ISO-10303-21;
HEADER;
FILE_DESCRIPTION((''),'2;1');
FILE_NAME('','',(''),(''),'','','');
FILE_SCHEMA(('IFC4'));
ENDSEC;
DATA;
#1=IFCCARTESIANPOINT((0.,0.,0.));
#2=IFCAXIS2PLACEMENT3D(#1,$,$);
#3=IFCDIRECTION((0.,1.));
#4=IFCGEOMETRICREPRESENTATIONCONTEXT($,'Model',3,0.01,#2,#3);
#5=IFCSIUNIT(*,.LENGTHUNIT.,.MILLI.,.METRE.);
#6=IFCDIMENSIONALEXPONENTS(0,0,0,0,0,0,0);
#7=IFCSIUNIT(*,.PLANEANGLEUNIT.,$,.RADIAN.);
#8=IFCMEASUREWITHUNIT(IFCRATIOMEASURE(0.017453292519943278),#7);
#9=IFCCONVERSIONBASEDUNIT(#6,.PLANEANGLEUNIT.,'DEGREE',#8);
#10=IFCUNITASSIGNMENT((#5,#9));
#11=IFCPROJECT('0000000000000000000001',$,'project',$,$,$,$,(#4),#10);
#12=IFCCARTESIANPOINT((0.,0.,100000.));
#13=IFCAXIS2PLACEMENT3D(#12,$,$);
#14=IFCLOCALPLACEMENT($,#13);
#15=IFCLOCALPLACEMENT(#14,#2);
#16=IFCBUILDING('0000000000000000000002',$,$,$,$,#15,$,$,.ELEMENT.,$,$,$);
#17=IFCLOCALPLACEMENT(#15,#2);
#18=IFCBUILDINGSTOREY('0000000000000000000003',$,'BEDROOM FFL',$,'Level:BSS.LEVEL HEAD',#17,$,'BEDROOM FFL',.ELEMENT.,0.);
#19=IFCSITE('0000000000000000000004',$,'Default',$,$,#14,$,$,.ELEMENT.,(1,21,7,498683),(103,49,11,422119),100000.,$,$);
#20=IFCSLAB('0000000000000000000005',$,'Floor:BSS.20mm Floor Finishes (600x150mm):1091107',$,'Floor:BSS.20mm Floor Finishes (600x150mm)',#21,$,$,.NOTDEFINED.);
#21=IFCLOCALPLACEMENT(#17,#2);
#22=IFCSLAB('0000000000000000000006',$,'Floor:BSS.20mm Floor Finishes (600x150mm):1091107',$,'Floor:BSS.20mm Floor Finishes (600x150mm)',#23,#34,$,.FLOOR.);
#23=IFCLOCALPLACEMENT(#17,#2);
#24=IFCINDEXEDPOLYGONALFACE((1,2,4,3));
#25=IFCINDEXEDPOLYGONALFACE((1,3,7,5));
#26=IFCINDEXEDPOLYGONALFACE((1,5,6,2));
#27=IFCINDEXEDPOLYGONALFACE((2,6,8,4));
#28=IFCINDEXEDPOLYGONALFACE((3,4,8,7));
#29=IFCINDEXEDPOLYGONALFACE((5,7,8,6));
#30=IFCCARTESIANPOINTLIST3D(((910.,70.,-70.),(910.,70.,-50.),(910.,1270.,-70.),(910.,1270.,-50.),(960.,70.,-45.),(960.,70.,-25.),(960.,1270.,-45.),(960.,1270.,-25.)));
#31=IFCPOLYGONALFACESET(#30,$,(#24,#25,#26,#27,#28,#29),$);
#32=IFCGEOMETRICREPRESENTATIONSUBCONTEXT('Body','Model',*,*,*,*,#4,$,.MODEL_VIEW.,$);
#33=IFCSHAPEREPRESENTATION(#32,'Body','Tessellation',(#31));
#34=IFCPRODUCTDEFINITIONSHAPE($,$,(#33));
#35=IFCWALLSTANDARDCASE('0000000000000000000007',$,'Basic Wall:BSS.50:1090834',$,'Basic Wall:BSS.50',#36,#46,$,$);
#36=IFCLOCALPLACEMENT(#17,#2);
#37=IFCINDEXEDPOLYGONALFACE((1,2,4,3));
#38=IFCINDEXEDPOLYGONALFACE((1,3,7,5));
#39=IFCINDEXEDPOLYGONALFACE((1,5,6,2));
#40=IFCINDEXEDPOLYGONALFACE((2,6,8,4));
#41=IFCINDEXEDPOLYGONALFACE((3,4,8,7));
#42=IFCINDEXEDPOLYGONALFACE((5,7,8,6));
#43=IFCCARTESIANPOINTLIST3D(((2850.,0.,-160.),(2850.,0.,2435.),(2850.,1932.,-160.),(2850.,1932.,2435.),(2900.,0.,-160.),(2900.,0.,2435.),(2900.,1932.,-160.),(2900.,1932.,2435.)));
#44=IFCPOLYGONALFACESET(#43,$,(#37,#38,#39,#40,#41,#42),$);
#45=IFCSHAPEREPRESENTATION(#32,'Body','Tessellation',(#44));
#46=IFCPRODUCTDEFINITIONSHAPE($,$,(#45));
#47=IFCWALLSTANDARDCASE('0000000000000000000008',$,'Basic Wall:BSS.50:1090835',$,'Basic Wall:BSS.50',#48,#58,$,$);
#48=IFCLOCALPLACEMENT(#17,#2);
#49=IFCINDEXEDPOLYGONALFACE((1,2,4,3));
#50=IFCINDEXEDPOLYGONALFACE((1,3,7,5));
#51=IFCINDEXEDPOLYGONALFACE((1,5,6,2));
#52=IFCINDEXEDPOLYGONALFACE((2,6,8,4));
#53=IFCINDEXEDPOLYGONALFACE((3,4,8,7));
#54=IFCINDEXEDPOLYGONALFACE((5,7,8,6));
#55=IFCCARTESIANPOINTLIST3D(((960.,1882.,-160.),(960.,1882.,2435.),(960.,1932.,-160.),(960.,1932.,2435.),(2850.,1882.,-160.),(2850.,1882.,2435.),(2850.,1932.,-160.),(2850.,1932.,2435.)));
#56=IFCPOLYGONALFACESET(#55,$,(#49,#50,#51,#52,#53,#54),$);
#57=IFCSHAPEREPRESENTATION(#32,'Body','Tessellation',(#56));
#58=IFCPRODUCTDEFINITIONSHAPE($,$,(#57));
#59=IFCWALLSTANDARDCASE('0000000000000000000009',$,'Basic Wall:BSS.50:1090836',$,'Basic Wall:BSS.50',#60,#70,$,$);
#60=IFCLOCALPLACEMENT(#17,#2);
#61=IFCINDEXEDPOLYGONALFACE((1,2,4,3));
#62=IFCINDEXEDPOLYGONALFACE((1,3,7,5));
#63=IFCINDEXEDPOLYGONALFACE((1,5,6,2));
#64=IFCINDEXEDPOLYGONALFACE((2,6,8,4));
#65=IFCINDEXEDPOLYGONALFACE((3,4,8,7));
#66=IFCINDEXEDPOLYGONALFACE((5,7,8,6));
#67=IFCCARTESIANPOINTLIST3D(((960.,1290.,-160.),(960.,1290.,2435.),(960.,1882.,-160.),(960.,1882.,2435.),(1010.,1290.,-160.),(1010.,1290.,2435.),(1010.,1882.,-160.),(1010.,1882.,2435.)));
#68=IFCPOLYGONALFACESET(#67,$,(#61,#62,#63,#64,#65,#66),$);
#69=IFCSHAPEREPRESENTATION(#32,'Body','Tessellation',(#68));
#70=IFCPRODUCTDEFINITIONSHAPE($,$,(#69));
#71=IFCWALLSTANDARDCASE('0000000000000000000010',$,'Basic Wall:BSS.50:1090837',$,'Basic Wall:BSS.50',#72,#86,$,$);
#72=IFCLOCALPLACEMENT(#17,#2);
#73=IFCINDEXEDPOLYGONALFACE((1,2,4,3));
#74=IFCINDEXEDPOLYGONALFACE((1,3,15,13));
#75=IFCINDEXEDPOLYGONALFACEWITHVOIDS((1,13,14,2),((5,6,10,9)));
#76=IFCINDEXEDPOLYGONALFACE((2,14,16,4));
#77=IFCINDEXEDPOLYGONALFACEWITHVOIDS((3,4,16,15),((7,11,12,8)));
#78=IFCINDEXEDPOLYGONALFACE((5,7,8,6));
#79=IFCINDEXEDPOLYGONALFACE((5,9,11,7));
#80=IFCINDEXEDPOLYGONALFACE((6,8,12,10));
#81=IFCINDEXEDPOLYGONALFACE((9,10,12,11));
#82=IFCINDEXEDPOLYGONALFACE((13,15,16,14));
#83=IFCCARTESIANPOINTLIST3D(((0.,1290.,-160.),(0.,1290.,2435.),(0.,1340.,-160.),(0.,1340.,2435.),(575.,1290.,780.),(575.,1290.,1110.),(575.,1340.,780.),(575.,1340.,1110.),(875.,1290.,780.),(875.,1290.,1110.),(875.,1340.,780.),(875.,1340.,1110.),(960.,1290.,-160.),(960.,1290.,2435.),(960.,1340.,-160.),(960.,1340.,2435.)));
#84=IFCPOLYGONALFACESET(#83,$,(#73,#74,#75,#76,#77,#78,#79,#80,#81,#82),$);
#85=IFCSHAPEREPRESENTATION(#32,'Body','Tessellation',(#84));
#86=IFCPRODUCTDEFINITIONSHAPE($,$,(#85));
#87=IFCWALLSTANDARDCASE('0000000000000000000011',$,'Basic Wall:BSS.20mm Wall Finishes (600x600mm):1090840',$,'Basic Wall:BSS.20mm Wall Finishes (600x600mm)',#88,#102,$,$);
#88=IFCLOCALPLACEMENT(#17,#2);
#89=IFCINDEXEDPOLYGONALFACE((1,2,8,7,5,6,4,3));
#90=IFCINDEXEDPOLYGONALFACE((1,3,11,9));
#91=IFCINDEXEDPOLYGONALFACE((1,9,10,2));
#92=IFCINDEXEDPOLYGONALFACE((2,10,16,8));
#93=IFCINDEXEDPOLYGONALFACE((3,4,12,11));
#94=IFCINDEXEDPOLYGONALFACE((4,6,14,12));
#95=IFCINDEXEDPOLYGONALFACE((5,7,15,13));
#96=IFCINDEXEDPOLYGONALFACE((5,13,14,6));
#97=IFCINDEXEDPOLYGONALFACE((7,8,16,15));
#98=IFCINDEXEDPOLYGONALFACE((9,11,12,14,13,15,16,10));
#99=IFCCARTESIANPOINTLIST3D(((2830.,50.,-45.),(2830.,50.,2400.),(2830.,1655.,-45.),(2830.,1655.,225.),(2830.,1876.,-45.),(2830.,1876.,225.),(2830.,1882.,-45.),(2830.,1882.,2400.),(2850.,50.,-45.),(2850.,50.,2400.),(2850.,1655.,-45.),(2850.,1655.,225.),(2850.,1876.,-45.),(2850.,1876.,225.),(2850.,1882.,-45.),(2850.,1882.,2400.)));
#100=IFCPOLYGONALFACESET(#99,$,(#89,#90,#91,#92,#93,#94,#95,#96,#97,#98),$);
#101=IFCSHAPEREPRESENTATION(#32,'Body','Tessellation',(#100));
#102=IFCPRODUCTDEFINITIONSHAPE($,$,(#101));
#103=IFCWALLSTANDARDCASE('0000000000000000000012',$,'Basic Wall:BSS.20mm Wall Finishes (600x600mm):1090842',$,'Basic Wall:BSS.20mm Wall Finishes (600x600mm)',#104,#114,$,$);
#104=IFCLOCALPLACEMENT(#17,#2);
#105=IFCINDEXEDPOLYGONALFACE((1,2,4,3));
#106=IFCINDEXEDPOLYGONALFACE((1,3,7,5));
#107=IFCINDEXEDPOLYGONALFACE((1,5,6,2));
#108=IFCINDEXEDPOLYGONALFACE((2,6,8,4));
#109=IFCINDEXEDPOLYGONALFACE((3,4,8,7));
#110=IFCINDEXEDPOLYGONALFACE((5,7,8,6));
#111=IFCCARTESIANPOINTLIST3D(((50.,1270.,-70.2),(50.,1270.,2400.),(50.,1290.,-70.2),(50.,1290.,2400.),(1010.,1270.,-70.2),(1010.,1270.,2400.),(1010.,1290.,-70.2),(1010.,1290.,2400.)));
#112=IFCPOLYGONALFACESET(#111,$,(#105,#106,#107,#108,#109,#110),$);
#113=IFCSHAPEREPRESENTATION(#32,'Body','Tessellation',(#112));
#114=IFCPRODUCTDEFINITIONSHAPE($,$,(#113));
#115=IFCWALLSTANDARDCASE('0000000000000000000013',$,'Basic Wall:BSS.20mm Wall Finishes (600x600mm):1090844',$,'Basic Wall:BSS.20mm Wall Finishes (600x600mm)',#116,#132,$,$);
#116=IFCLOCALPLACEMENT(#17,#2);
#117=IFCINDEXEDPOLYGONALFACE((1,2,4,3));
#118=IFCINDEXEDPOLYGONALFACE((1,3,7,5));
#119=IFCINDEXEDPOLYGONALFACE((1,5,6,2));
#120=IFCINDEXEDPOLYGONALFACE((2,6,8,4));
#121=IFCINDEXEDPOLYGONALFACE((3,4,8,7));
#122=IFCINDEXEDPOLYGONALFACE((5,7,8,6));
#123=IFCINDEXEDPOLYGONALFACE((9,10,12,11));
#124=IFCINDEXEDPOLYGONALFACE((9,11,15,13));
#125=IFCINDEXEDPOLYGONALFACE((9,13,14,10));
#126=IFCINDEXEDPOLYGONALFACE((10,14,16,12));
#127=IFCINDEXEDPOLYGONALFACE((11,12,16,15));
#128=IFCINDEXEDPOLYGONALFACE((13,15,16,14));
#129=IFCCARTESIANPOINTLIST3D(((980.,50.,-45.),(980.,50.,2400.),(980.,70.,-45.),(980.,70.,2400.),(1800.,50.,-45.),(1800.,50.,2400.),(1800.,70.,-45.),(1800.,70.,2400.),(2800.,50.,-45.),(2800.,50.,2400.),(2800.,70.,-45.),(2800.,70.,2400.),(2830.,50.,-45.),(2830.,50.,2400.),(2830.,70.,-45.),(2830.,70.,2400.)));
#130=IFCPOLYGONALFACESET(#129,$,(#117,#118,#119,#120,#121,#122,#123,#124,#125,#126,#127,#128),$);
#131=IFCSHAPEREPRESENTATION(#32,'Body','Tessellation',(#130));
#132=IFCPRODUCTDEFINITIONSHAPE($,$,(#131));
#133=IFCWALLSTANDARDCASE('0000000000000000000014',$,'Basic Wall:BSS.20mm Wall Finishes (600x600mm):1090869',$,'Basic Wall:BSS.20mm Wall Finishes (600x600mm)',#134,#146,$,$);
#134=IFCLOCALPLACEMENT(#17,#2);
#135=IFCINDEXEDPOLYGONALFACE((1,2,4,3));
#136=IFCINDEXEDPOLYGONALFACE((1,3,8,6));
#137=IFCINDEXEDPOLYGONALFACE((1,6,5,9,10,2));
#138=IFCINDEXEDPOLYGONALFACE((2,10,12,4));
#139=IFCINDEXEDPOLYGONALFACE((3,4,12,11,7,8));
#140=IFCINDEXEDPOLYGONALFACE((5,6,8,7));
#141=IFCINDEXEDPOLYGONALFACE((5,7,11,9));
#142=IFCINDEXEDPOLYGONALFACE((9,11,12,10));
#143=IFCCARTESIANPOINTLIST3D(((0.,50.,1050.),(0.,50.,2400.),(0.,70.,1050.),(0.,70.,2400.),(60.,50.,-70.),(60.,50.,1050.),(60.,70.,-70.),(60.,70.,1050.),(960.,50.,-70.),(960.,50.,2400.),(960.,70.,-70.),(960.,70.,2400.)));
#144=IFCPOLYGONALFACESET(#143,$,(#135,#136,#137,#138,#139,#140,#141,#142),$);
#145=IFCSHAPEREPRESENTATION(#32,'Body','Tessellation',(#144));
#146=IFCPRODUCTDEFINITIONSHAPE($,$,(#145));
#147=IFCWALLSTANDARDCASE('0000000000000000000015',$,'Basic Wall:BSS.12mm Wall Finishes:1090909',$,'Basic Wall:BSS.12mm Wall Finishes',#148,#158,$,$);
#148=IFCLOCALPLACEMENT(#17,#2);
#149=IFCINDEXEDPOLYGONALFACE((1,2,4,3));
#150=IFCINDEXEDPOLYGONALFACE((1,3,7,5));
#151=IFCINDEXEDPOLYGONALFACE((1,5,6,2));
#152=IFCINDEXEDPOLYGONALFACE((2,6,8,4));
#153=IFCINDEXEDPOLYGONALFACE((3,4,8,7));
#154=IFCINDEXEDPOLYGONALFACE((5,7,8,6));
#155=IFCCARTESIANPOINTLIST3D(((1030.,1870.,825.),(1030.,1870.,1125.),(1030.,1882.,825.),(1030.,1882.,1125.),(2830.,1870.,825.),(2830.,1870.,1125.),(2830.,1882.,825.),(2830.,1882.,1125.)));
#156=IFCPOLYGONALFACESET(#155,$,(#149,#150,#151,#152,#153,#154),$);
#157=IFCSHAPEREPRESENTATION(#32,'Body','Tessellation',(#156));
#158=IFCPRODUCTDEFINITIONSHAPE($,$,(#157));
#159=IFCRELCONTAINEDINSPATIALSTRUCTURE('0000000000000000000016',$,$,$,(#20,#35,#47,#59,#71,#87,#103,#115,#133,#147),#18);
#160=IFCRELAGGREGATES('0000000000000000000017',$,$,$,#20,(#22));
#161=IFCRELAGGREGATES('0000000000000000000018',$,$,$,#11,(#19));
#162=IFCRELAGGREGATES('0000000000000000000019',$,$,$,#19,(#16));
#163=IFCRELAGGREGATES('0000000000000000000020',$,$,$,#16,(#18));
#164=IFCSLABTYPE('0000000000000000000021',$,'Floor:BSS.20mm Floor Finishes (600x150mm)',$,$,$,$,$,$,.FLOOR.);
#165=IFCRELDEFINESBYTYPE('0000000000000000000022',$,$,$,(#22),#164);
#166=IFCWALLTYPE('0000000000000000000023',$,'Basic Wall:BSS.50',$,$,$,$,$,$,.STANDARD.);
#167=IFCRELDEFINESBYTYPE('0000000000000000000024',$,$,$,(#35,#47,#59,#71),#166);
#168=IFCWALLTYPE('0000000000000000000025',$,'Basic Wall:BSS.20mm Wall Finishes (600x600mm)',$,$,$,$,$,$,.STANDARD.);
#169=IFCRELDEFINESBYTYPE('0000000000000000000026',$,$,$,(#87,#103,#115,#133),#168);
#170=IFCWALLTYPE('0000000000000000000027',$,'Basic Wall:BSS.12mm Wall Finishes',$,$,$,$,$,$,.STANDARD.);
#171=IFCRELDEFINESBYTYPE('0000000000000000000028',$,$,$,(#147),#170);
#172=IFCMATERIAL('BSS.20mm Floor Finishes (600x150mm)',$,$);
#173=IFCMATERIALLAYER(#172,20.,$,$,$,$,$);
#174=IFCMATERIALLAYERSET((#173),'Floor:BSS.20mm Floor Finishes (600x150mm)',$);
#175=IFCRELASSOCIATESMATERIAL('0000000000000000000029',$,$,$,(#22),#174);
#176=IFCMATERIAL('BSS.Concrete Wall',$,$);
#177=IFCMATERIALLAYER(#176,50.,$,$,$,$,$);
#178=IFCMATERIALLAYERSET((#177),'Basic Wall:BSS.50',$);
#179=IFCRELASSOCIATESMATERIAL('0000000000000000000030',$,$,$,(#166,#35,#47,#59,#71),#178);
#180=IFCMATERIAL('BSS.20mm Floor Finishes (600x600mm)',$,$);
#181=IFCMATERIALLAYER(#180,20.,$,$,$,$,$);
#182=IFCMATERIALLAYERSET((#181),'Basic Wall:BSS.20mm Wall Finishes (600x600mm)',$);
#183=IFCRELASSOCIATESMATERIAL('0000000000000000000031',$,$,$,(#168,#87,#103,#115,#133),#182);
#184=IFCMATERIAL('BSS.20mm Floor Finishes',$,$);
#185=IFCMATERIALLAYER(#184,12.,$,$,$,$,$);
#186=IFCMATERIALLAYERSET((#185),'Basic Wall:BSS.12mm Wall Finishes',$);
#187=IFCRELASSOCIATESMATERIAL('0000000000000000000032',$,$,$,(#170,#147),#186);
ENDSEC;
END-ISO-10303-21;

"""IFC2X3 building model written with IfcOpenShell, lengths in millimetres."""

from ifc_helpers import new_model, entity, si_unit, converted_unit, direction, frame, frame_2d, origin, place, context, subcontext, project, spatial, rectangle, extrude, clip, halfspace, material, layer, layer_set, layer_usage, type_object, element, aggregate, save


model = new_model("IFC2X3")

# Units and contexts
model_context = context("Model", 3, precision=0.01, world=origin(), true_north=direction((0.0, 1.0)))
body_context = subcontext(model_context, "Body", "Model", "MODEL_VIEW")
ifc_project = project(units=[si_unit("LENGTHUNIT", "METRE", prefix="MILLI"), converted_unit("PLANEANGLEUNIT", "DEGREE", entity("IfcRatioMeasure", 0.017453292519943278), si_unit("PLANEANGLEUNIT", "RADIAN"), dimensions=[0, 0, 0, 0, 0, 0, 0])], contexts=[model_context])

# Site, building, storey
site_placement = place(None, frame((0.0, 0.0, 100000.0)))
site = spatial("IfcSite", under=ifc_project, at=site_placement, Name="Default", CompositionType="ELEMENT", RefLatitude=(1, 21, 7, 498683), RefLongitude=(103, 49, 11, 422119), RefElevation=100000.0)
building_placement = place(site_placement, origin())
building = spatial("IfcBuilding", under=site, at=building_placement, CompositionType="ELEMENT")
storey_placement = place(building_placement, origin())
storey = spatial("IfcBuildingStorey", under=building, at=storey_placement, Name="BEDROOM FFL", ObjectType="Level:BSS.LEVEL HEAD", LongName="BEDROOM FFL", CompositionType="ELEMENT", Elevation=0.0)

# Slabs
slab_1_placement = place(storey_placement, frame((910.0, 70.0, -70.0)))
slab_1 = element("IfcSlab", 1, at=slab_1_placement, inside=storey, Name="Floor:BSS.20mm Floor Finishes (600x150mm):1091107", ObjectType="Floor:BSS.20mm Floor Finishes (600x150mm)", PredefinedType="NOTDEFINED")
ifc_material_1 = material(Name="BSS.20mm Floor Finishes (600x150mm)")
ifc_layer_1 = layer(ifc_material_1, 20.0)
ifc_layer_set_1 = layer_set([ifc_layer_1], Name="Floor:BSS.20mm Floor Finishes (600x150mm)")
slab_type_1 = type_object("IfcSlabType", Name="Floor:BSS.20mm Floor Finishes (600x150mm)", PredefinedType="FLOOR")
slab_2_placement = place(slab_1_placement, origin())
slab_2 = element("IfcSlab", 2, at=slab_2_placement, type_object=slab_type_1, material=ifc_layer_set_1, Name="Floor:BSS.20mm Floor Finishes (600x150mm):1091107", ObjectType="Floor:BSS.20mm Floor Finishes (600x150mm)", PredefinedType="FLOOR", context=body_context, shape_type="SweptSolid", body=[
    extrude(rectangle(XDim=1200.0, YDim=55.9, at=frame_2d((0.0, 0.0), x_axis=(0.0, -1.0))), frame((25.0, 600.0, 32.5), z_axis=(-0.447227, 0.0, 0.89442), x_axis=(0.89442, 0.0, 0.447227)), (-0.447227, 0.0, -0.89442), 20.0),
])
aggregate(slab_1, [slab_2])

# Walls
ifc_material_2 = material(Name="BSS.Concrete Wall")
ifc_layer_2 = layer(ifc_material_2, 50.0)
ifc_layer_set_2 = layer_set([ifc_layer_2], Name="Basic Wall:BSS.50")
ifc_layer_usage_1 = layer_usage(ifc_layer_set_2, "AXIS2", "POSITIVE", -25.0)
wall_type_1 = type_object("IfcWallType", Name="Basic Wall:BSS.50", PredefinedType="STANDARD", material=ifc_layer_set_2)
wall_1_placement = place(storey_placement, frame((2875.0, 0.0, -160.0), z_axis=(0.0, 0.0, 1.0), x_axis=(0.0, 1.0, 0.0)))
element("IfcWallStandardCase", 3, at=wall_1_placement, inside=storey, type_object=wall_type_1, material=ifc_layer_usage_1, Name="Basic Wall:BSS.50:1090834", ObjectType="Basic Wall:BSS.50", context=body_context, shape_type="SweptSolid", body=[
    extrude(rectangle(XDim=1932.0, YDim=50.0, at=frame_2d((966.0, 0.0), x_axis=(-1.0, 0.0))), origin(), (0.0, 0.0, 1.0), 2595.0),
])
ifc_layer_usage_2 = layer_usage(ifc_layer_set_2, "AXIS2", "NEGATIVE", 25.0)
wall_2_placement = place(storey_placement, frame((2850.0, 1907.0, -160.0), z_axis=(0.0, 0.0, 1.0), x_axis=(-1.0, 0.0, 0.0)))
element("IfcWallStandardCase", 4, at=wall_2_placement, inside=storey, type_object=wall_type_1, material=ifc_layer_usage_2, Name="Basic Wall:BSS.50:1090835", ObjectType="Basic Wall:BSS.50", context=body_context, shape_type="SweptSolid", body=[
    extrude(rectangle(XDim=1890.0, YDim=50.0, at=frame_2d((945.0, 0.0), x_axis=(-1.0, 0.0))), origin(), (0.0, 0.0, 1.0), 2595.0),
])
ifc_layer_usage_3 = layer_usage(ifc_layer_set_2, "AXIS2", "NEGATIVE", 25.0)
wall_3_placement = place(storey_placement, frame((985.0, 1882.0, -160.0), z_axis=(0.0, 0.0, 1.0), x_axis=(0.0, -1.0, 0.0)))
element("IfcWallStandardCase", 5, at=wall_3_placement, inside=storey, type_object=wall_type_1, material=ifc_layer_usage_3, Name="Basic Wall:BSS.50:1090836", ObjectType="Basic Wall:BSS.50", context=body_context, shape_type="SweptSolid", body=[
    extrude(rectangle(XDim=592.0, YDim=50.0, at=frame_2d((296.0, 0.0), x_axis=(-1.0, 0.0))), origin(), (0.0, 0.0, 1.0), 2595.0),
])

# Walls, openings
ifc_layer_usage_4 = layer_usage(ifc_layer_set_2, "AXIS2", "NEGATIVE", 25.0)
wall_4_placement = place(storey_placement, frame((960.0, 1315.0, -160.0), z_axis=(0.0, 0.0, 1.0), x_axis=(-1.0, 0.0, 0.0)))
wall_4 = element("IfcWallStandardCase", 6, at=wall_4_placement, inside=storey, type_object=wall_type_1, material=ifc_layer_usage_4, Name="Basic Wall:BSS.50:1090837", ObjectType="Basic Wall:BSS.50", context=body_context, shape_type="SweptSolid", body=[
    extrude(rectangle(XDim=960.0, YDim=50.0, at=frame_2d((480.0, 0.0), x_axis=(-1.0, 0.0))), origin(), (0.0, 0.0, 1.0), 2595.0),
])
opening_1_placement = place(wall_4_placement, origin())
element("IfcOpeningElement", 7, at=opening_1_placement, cuts=wall_4, ObjectType="Opening", context=body_context, shape_type="SweptSolid", body=[
    extrude(rectangle(XDim=330.0, YDim=300.0, at=frame_2d((0.0, 0.0), x_axis=(0.0, 1.0))), frame((235.0, 25.0, 1105.0), z_axis=(0.0, -1.0, 0.0), x_axis=(-1.0, 0.0, 0.0)), (0.0, 0.0, 1.0), 50.0),
])
ifc_material_3 = material(Name="BSS.20mm Floor Finishes (600x600mm)")
ifc_layer_3 = layer(ifc_material_3, 20.0)
ifc_layer_set_3 = layer_set([ifc_layer_3], Name="Basic Wall:BSS.20mm Wall Finishes (600x600mm)")
ifc_layer_usage_5 = layer_usage(ifc_layer_set_3, "AXIS2", "POSITIVE", -10.0)
wall_type_2 = type_object("IfcWallType", Name="Basic Wall:BSS.20mm Wall Finishes (600x600mm)", PredefinedType="STANDARD", material=ifc_layer_set_3)
wall_5_placement = place(storey_placement, frame((2840.0, 50.0, -45.0), z_axis=(0.0, 0.0, 1.0), x_axis=(0.0, 1.0, 0.0)))
wall_5 = element("IfcWallStandardCase", 8, at=wall_5_placement, inside=storey, type_object=wall_type_2, material=ifc_layer_usage_5, Name="Basic Wall:BSS.20mm Wall Finishes (600x600mm):1090840", ObjectType="Basic Wall:BSS.20mm Wall Finishes (600x600mm)", context=body_context, shape_type="SweptSolid", body=[
    extrude(rectangle(XDim=1832.0, YDim=20.0, at=frame_2d((916.0, 0.0), x_axis=(-1.0, 0.0))), origin(), (0.0, 0.0, 1.0), 2445.0),
])
opening_2_placement = place(wall_5_placement, origin())
element("IfcOpeningElement", 9, at=opening_2_placement, cuts=wall_5, ObjectType="Opening", context=body_context, shape_type="SweptSolid", body=[
    extrude(rectangle(XDim=270.0, YDim=221.0, at=frame_2d((0.0, 0.0), x_axis=(0.0, 1.0))), frame((1715.5, 10.0, 135.0), z_axis=(0.0, -1.0, 0.0), x_axis=(1.0, 0.0, 0.0)), (0.0, 0.0, 1.0), 20.0),
])

# Wall
ifc_layer_usage_6 = layer_usage(ifc_layer_set_3, "AXIS2", "POSITIVE", -10.0)
wall_6_placement = place(storey_placement, frame((1010.0, 1280.0, -70.2), z_axis=(0.0, 0.0, 1.0), x_axis=(-1.0, 0.0, 0.0)))
element("IfcWallStandardCase", 10, at=wall_6_placement, inside=storey, type_object=wall_type_2, material=ifc_layer_usage_6, Name="Basic Wall:BSS.20mm Wall Finishes (600x600mm):1090842", ObjectType="Basic Wall:BSS.20mm Wall Finishes (600x600mm)", context=body_context, shape_type="SweptSolid", body=[
    extrude(rectangle(XDim=960.0, YDim=20.0, at=frame_2d((480.0, 0.0), x_axis=(-1.0, 0.0))), origin(), (0.0, 0.0, 1.0), 2470.2),
])

# Wall, opening
ifc_layer_usage_7 = layer_usage(ifc_layer_set_3, "AXIS2", "POSITIVE", -10.0)
wall_7_placement = place(storey_placement, frame((980.0, 60.0, -45.0)))
wall_7 = element("IfcWallStandardCase", 11, at=wall_7_placement, inside=storey, type_object=wall_type_2, material=ifc_layer_usage_7, Name="Basic Wall:BSS.20mm Wall Finishes (600x600mm):1090844", ObjectType="Basic Wall:BSS.20mm Wall Finishes (600x600mm)", context=body_context, shape_type="SweptSolid", body=[
    extrude(rectangle(XDim=20.0, YDim=1850.0, at=frame_2d((925.0, 0.0), x_axis=(0.0, -1.0))), origin(), (0.0, 0.0, 1.0), 2445.0),
])
opening_3_placement = place(wall_7_placement, frame((-980.0, -60.0, 45.0)))
element("IfcOpeningElement", 12, at=opening_3_placement, cuts=wall_7, ObjectType="Opening", context=body_context, shape_type="SweptSolid", body=[
    extrude(rectangle(XDim=2445.0, YDim=1000.0, at=frame_2d((0.0, 0.0), x_axis=(1.0, 0.0))), frame((2300.0, -1474.0, 1177.5), z_axis=(0.0, 1.0, 0.0), x_axis=(0.0, 0.0, -1.0)), (0.0, 0.0, 1.0), 3048.0),
])

# Wall, openings
ifc_layer_usage_8 = layer_usage(ifc_layer_set_3, "AXIS2", "POSITIVE", -10.0)
wall_8_placement = place(storey_placement, frame((960.0, 60.0, -70.0), z_axis=(0.0, 0.0, 1.0), x_axis=(-1.0, 0.0, 0.0)))
wall_8 = element("IfcWallStandardCase", 13, at=wall_8_placement, inside=storey, type_object=wall_type_2, material=ifc_layer_usage_8, Name="Basic Wall:BSS.20mm Wall Finishes (600x600mm):1090869", ObjectType="Basic Wall:BSS.20mm Wall Finishes (600x600mm)", context=body_context, shape_type="SweptSolid", body=[
    extrude(rectangle(XDim=960.0, YDim=20.0, at=frame_2d((480.0, 0.0), x_axis=(-1.0, 0.0))), origin(), (0.0, 0.0, 1.0), 2470.0),
])
opening_4_placement = place(wall_8_placement, origin())
element("IfcOpeningElement", 14, at=opening_4_placement, cuts=wall_8, ObjectType="Opening", context=body_context, shape_type="SweptSolid", body=[
    extrude(rectangle(XDim=1350.0, YDim=20.0, at=frame_2d((0.0, 0.0), x_axis=(0.0, 1.0))), frame((900.0, -710.0, 1795.0), z_axis=(0.0, 1.0, 0.0), x_axis=(-1.0, 0.0, 0.0)), (0.0, 0.0, 1.0), 700.0),
])
opening_5_placement = place(wall_8_placement, origin())
element("IfcOpeningElement", 15, at=opening_5_placement, cuts=wall_8, ObjectType="Opening", context=body_context, shape_type="SweptSolid", body=[
    extrude(rectangle(XDim=1120.0, YDim=60.0, at=frame_2d((0.0, 0.0), x_axis=(0.0, 1.0))), frame((930.0, 10.0, 560.0), z_axis=(0.0, -1.0, 0.0), x_axis=(1.0, 0.0, 0.0)), (0.0, 0.0, 1.0), 20.0),
])

# Wall
ifc_material_4 = material(Name="BSS.20mm Floor Finishes")
ifc_layer_4 = layer(ifc_material_4, 12.0)
ifc_layer_set_4 = layer_set([ifc_layer_4], Name="Basic Wall:BSS.12mm Wall Finishes")
ifc_layer_usage_9 = layer_usage(ifc_layer_set_4, "AXIS2", "POSITIVE", -6.0)
wall_type_3 = type_object("IfcWallType", Name="Basic Wall:BSS.12mm Wall Finishes", PredefinedType="STANDARD", material=ifc_layer_set_4)
wall_9_placement = place(storey_placement, frame((2830.0, 1876.0, 825.0), z_axis=(0.0, 0.0, 1.0), x_axis=(-1.0, 0.0, 0.0)))
element("IfcWallStandardCase", 16, at=wall_9_placement, inside=storey, type_object=wall_type_3, material=ifc_layer_usage_9, Name="Basic Wall:BSS.12mm Wall Finishes:1090909", ObjectType="Basic Wall:BSS.12mm Wall Finishes", context=body_context, shape_type="Clipping", body=[
    clip(extrude(rectangle(XDim=1800.0, YDim=12.0, at=frame_2d((900.0, 0.0), x_axis=(-1.0, 0.0))), origin(), (0.0, 0.0, 1.0), 300.0), halfspace(frame((0.0, -6.0, 300.0), z_axis=(0.0, 0.0, 1.0), x_axis=(0.0, 1.0, 0.0)), False)),
])

save(model, "model.ifc")
